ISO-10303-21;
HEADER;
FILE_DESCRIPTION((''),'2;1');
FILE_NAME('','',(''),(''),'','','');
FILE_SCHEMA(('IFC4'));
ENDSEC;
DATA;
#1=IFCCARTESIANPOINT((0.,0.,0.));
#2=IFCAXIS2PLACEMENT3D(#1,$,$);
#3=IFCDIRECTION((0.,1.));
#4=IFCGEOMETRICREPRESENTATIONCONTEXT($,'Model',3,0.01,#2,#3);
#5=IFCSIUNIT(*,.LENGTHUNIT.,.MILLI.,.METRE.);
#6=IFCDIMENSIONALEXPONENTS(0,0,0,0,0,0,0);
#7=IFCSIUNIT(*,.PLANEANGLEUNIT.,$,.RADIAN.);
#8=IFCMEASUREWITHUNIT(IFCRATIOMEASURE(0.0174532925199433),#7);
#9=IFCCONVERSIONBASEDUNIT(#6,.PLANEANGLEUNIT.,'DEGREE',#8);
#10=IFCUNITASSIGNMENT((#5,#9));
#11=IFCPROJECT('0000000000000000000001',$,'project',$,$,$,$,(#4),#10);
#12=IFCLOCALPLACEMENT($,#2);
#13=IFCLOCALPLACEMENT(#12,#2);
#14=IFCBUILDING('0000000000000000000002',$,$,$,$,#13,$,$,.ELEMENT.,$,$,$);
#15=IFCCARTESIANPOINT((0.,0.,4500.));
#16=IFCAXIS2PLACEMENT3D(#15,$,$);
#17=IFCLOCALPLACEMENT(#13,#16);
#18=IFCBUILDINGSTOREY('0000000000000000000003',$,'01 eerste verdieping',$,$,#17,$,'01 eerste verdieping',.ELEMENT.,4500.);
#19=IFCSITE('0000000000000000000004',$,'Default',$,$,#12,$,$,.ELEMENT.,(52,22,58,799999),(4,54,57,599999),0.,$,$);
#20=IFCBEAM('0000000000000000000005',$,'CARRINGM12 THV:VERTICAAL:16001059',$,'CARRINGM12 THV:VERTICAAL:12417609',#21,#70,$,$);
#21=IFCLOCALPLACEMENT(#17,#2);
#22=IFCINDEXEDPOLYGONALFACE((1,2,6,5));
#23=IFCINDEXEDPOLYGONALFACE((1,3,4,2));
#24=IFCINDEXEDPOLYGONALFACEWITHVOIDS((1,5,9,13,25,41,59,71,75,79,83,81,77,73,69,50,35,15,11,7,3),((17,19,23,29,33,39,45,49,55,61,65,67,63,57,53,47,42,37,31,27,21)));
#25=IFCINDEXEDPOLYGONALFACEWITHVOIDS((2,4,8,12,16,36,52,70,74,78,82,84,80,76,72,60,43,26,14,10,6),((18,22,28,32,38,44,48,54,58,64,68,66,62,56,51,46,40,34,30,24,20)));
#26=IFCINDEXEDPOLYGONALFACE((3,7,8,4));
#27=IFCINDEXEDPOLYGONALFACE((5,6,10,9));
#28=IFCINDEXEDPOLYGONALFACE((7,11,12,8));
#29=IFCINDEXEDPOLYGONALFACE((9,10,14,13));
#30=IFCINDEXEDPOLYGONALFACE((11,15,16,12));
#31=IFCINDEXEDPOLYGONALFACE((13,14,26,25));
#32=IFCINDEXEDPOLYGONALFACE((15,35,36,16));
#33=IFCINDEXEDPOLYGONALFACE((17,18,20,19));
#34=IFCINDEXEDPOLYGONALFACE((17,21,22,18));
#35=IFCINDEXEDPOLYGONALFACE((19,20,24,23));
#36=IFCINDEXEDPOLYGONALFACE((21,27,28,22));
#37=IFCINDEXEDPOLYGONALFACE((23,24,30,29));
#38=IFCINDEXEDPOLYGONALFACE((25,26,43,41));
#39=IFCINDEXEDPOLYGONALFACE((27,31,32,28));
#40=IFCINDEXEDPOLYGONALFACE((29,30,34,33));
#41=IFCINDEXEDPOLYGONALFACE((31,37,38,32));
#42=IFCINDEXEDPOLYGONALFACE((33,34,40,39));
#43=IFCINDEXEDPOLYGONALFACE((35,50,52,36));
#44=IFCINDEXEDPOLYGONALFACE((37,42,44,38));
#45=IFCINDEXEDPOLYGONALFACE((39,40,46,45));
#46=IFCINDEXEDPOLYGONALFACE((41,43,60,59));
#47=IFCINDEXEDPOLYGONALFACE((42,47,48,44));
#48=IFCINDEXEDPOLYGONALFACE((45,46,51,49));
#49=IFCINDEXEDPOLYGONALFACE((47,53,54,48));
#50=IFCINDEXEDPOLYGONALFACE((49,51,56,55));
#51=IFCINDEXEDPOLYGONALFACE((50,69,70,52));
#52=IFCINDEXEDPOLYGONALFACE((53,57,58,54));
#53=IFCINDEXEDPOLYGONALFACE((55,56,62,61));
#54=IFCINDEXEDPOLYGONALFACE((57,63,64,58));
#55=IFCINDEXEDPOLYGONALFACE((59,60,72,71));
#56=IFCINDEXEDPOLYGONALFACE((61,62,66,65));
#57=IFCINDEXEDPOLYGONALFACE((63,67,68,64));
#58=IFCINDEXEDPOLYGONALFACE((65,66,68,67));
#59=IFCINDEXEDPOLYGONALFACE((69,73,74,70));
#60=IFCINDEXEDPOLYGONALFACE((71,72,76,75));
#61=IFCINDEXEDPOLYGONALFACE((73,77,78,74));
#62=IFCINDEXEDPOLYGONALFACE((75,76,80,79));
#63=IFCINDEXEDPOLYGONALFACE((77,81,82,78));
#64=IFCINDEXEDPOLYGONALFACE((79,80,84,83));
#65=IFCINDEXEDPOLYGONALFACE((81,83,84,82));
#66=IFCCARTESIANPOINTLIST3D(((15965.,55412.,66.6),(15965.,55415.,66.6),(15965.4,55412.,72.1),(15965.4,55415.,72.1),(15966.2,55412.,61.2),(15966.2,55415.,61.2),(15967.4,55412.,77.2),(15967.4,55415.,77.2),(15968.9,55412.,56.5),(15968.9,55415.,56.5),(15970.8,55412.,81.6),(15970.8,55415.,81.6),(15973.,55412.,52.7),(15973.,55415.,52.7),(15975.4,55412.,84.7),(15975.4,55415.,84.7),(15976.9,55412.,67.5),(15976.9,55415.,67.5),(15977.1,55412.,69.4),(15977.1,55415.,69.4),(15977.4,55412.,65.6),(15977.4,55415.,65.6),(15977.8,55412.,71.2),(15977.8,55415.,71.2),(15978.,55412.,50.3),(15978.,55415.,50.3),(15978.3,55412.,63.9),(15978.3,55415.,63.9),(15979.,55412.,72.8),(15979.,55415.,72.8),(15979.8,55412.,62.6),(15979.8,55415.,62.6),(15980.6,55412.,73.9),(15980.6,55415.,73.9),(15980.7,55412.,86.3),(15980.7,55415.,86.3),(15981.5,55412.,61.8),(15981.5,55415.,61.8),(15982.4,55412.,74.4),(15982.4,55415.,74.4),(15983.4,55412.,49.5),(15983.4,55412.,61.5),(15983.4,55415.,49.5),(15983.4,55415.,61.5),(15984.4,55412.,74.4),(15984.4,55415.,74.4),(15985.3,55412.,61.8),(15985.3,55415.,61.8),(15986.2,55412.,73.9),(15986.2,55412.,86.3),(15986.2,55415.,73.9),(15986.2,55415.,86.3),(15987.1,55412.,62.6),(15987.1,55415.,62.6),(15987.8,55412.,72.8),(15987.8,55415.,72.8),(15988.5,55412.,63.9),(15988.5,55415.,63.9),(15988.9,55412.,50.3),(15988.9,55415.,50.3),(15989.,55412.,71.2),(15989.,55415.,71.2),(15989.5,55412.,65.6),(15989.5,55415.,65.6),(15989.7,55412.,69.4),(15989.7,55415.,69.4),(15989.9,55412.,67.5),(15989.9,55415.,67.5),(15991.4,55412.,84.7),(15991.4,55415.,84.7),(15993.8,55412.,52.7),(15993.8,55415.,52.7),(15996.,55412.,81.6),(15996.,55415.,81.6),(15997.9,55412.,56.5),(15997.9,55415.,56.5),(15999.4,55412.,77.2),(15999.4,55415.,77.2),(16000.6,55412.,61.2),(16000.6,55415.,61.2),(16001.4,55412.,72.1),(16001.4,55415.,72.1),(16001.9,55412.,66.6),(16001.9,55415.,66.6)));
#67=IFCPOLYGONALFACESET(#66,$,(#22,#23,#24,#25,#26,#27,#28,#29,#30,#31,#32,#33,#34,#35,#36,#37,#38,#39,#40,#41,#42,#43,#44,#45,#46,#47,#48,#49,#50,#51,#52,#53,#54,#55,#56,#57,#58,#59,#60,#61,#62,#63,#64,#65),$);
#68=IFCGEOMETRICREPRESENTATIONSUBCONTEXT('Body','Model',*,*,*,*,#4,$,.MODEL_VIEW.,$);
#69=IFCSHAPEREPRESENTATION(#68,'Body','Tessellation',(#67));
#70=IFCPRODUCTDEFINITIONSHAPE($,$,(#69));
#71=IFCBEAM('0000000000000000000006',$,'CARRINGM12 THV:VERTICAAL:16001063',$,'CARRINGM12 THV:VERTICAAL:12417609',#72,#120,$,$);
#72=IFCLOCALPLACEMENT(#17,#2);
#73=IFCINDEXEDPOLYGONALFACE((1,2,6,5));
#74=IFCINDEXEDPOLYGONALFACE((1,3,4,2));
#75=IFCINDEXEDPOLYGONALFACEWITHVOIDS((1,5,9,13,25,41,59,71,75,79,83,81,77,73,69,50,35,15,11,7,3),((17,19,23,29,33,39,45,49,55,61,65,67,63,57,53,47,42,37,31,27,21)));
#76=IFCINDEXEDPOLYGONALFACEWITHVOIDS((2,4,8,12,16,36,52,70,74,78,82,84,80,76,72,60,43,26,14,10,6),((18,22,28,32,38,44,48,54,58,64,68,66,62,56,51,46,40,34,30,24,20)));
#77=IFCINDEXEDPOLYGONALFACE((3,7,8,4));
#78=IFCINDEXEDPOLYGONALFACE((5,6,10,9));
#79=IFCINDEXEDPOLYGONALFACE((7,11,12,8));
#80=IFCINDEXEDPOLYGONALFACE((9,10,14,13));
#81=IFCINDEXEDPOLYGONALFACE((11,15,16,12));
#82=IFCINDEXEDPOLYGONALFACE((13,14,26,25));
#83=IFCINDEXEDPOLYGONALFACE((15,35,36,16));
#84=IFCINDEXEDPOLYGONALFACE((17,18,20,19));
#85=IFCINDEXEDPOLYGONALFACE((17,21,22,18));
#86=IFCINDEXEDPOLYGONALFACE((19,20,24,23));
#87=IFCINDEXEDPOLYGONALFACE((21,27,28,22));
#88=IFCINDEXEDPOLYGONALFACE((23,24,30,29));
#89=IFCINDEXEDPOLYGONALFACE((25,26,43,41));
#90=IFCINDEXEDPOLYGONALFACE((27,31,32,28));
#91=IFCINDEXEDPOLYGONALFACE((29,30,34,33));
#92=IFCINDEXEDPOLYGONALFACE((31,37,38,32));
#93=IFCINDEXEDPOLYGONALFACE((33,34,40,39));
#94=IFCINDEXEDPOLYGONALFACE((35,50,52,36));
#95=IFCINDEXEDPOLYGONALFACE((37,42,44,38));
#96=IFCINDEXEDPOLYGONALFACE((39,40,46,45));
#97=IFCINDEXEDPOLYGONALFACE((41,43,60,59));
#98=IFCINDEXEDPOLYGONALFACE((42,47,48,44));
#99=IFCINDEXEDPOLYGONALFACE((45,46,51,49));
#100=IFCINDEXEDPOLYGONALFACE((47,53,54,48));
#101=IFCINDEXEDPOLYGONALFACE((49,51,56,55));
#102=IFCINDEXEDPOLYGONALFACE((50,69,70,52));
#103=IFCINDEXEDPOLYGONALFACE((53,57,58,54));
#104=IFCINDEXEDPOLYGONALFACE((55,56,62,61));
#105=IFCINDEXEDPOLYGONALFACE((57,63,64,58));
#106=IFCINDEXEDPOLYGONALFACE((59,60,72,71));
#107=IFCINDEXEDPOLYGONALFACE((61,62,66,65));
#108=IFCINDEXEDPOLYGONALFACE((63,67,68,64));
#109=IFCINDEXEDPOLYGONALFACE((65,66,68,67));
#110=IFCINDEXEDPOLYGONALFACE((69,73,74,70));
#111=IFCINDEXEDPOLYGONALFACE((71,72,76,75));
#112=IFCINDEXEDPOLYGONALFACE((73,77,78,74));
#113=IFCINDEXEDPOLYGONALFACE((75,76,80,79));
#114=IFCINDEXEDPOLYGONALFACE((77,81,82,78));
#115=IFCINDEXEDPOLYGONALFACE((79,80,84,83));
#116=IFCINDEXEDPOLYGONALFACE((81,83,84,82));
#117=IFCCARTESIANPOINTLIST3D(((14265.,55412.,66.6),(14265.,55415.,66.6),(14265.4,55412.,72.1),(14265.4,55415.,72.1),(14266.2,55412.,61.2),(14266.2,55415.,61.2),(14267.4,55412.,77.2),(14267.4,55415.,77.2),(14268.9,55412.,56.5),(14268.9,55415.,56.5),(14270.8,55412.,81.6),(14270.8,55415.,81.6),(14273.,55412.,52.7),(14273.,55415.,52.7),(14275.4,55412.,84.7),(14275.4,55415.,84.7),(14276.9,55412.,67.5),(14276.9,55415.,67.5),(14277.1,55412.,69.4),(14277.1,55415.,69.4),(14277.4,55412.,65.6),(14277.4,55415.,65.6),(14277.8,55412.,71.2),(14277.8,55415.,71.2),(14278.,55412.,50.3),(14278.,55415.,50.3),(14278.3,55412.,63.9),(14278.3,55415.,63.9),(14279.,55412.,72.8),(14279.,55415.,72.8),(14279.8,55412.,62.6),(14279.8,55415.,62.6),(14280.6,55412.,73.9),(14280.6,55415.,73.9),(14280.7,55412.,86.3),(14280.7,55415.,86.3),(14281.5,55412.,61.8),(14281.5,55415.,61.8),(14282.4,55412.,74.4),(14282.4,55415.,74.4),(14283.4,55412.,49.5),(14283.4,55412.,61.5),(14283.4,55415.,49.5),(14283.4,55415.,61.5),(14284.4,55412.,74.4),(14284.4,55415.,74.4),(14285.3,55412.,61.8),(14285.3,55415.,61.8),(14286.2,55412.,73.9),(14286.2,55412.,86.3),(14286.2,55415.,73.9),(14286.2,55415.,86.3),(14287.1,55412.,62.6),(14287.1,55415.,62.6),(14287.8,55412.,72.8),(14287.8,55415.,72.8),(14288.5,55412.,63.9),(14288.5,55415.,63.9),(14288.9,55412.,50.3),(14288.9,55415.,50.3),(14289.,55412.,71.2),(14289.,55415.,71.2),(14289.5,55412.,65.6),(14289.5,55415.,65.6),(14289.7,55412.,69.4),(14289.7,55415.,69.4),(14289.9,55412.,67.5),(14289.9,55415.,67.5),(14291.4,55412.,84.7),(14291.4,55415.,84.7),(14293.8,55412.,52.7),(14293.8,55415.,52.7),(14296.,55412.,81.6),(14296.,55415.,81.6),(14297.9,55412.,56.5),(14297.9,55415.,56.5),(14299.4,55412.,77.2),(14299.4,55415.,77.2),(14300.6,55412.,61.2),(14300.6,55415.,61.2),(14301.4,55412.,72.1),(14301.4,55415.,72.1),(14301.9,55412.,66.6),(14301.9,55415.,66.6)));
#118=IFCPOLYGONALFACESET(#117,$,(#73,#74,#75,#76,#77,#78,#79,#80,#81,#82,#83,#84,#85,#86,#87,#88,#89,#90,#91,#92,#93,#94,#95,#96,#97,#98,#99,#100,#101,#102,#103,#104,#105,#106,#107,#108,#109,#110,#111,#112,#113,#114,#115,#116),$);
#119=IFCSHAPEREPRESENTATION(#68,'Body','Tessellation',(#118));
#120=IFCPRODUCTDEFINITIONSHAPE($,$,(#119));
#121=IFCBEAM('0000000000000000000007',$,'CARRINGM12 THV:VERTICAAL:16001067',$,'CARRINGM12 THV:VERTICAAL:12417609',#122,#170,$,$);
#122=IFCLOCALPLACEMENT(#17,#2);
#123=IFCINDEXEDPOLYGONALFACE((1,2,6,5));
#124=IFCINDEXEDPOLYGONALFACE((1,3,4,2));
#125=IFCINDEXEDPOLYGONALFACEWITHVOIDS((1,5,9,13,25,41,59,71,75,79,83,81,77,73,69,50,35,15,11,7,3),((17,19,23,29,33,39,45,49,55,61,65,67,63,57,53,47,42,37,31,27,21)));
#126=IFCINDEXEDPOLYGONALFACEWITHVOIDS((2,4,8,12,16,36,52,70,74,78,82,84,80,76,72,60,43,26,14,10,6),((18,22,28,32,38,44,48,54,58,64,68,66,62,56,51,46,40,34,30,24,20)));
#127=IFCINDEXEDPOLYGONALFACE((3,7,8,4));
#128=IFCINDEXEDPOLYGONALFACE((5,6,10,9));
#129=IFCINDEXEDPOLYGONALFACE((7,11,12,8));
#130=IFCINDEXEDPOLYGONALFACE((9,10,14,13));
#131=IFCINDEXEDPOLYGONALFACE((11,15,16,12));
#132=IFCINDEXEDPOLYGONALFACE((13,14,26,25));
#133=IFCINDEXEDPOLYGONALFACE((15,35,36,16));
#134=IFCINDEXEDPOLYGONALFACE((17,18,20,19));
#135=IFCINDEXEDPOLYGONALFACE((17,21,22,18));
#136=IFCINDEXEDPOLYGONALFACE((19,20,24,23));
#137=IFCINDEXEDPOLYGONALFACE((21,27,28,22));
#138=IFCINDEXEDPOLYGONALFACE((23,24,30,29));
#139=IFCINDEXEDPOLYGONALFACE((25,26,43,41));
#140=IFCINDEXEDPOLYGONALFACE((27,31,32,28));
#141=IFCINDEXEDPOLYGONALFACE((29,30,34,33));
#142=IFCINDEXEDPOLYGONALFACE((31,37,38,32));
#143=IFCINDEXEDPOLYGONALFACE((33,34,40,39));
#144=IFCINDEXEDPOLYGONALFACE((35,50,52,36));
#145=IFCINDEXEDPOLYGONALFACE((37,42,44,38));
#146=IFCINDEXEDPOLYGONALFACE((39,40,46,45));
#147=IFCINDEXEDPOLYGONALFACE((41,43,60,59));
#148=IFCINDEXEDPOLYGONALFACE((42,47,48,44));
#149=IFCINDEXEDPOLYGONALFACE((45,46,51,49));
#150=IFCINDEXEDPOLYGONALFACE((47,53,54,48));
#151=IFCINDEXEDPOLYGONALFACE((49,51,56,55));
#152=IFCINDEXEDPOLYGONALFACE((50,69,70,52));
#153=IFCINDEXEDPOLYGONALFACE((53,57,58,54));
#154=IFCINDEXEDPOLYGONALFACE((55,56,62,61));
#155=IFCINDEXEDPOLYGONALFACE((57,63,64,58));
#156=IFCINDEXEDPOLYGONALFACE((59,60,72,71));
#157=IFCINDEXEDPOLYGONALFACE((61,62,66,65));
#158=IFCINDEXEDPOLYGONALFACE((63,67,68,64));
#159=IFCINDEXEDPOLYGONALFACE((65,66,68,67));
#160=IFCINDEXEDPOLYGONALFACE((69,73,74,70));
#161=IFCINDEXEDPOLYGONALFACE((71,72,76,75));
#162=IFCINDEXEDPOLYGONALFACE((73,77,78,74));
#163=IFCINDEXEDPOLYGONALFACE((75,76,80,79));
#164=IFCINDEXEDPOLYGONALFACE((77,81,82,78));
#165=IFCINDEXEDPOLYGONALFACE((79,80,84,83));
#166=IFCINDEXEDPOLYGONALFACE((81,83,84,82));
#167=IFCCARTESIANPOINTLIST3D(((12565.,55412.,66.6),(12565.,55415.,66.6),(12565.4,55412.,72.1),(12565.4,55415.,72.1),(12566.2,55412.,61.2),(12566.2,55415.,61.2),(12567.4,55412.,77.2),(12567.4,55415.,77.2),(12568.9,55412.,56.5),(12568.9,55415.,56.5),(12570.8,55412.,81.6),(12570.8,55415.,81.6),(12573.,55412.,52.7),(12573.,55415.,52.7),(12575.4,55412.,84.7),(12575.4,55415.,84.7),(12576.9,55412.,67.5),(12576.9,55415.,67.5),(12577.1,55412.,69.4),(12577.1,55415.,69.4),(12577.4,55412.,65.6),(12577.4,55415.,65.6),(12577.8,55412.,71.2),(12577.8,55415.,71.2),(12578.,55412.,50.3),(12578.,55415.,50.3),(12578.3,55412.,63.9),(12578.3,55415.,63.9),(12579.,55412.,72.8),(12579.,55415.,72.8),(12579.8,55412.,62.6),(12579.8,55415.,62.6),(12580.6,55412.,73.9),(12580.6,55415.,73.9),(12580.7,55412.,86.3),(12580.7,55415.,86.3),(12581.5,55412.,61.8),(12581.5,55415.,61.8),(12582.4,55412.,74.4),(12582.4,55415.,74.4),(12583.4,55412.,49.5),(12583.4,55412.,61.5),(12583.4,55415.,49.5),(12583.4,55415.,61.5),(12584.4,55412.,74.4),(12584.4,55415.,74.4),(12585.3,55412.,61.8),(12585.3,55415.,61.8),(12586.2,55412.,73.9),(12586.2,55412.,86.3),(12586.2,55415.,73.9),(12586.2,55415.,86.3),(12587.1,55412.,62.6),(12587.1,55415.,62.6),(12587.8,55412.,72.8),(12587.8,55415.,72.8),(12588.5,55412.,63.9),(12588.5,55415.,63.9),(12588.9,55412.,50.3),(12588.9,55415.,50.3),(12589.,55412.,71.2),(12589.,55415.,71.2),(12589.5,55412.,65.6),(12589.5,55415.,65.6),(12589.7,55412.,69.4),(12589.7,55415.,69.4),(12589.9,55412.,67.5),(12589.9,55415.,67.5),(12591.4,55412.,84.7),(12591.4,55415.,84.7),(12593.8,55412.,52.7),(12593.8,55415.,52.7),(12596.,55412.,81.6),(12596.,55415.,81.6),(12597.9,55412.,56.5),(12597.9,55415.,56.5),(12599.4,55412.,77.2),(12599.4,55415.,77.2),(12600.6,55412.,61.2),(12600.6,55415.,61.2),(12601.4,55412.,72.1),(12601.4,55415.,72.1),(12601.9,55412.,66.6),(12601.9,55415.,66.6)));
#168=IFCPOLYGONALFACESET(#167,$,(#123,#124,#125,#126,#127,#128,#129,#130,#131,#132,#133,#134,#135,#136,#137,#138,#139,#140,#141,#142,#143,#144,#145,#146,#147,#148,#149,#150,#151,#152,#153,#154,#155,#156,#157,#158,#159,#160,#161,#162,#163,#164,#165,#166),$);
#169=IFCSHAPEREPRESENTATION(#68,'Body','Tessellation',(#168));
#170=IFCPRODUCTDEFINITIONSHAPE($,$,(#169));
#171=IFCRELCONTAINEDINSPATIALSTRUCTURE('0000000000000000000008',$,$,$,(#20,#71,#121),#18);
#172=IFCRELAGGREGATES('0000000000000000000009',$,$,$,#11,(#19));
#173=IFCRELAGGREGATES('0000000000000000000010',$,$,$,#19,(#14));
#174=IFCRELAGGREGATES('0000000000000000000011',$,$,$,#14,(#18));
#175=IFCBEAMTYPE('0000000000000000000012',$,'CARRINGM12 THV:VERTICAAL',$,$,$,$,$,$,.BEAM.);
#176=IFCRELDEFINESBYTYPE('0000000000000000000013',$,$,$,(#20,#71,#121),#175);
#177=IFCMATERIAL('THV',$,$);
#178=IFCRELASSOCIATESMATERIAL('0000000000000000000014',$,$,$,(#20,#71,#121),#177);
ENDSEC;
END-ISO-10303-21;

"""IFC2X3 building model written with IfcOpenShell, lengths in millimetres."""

from ifc_helpers import new_model, entity, si_unit, converted_unit, direction, frame, origin, origin_2d_with_axis, place, context, subcontext, project, spatial, hollow_circle, extrude, material, type_object, element, save


model = new_model("IFC2X3")

# Units and contexts
model_context = context("Model", 3, precision=0.01, world=origin(), true_north=direction((0.0, 1.0)))
body_context = subcontext(model_context, "Body", "Model", "MODEL_VIEW")
ifc_project = project(units=[si_unit("LENGTHUNIT", "METRE", prefix="MILLI"), converted_unit("PLANEANGLEUNIT", "DEGREE", entity("IfcRatioMeasure", 0.0174532925199433), si_unit("PLANEANGLEUNIT", "RADIAN"), dimensions=[0, 0, 0, 0, 0, 0, 0])], contexts=[model_context])

# Site, building, storey
site_placement = place(None, origin())
site = spatial("IfcSite", under=ifc_project, at=site_placement, Name="Default", CompositionType="ELEMENT", RefLatitude=(52, 22, 58, 799999), RefLongitude=(4, 54, 57, 599999), RefElevation=0.0)
building_placement = place(site_placement, origin())
building = spatial("IfcBuilding", under=site, at=building_placement, CompositionType="ELEMENT")
storey_placement = place(building_placement, frame((0.0, 0.0, 4500.0)))
storey = spatial("IfcBuildingStorey", under=building, at=storey_placement, Name="01 eerste verdieping", LongName="01 eerste verdieping", CompositionType="ELEMENT", Elevation=4500.0)

# Beams
ifc_material_1 = material(Name="THV")
beam_type_1 = type_object("IfcBeamType", Name="CARRINGM12 THV:VERTICAAL", PredefinedType="BEAM")
beam_1_placement = place(storey_placement, origin())
element("IfcBeam", 1, at=beam_1_placement, inside=storey, type_object=beam_type_1, material=ifc_material_1, Name="CARRINGM12 THV:VERTICAAL:16001059", ObjectType="CARRINGM12 THV:VERTICAAL:12417609", context=body_context, shape_type="SweptSolid", body=[
    extrude(hollow_circle(Radius=18.5, WallThickness=12.0, at=origin_2d_with_axis()), frame((15983.4, 55412.0, 68.0), z_axis=(0.0, 1.0, 0.0), x_axis=(0.0, 0.0, -1.0)), (0.0, 0.0, 1.0), 3.0),
])
beam_2_placement = place(storey_placement, origin())
element("IfcBeam", 2, at=beam_2_placement, inside=storey, type_object=beam_type_1, material=ifc_material_1, Name="CARRINGM12 THV:VERTICAAL:16001063", ObjectType="CARRINGM12 THV:VERTICAAL:12417609", context=body_context, shape_type="SweptSolid", body=[
    extrude(hollow_circle(Radius=18.5, WallThickness=12.0, at=origin_2d_with_axis()), frame((14283.4, 55412.0, 68.0), z_axis=(0.0, 1.0, 0.0), x_axis=(0.0, 0.0, -1.0)), (0.0, 0.0, 1.0), 3.0),
])
beam_3_placement = place(storey_placement, origin())
element("IfcBeam", 3, at=beam_3_placement, inside=storey, type_object=beam_type_1, material=ifc_material_1, Name="CARRINGM12 THV:VERTICAAL:16001067", ObjectType="CARRINGM12 THV:VERTICAAL:12417609", context=body_context, shape_type="SweptSolid", body=[
    extrude(hollow_circle(Radius=18.5, WallThickness=12.0, at=origin_2d_with_axis()), frame((12583.4, 55412.0, 68.0), z_axis=(0.0, 1.0, 0.0), x_axis=(0.0, 0.0, -1.0)), (0.0, 0.0, 1.0), 3.0),
])

save(model, "model.ifc")
